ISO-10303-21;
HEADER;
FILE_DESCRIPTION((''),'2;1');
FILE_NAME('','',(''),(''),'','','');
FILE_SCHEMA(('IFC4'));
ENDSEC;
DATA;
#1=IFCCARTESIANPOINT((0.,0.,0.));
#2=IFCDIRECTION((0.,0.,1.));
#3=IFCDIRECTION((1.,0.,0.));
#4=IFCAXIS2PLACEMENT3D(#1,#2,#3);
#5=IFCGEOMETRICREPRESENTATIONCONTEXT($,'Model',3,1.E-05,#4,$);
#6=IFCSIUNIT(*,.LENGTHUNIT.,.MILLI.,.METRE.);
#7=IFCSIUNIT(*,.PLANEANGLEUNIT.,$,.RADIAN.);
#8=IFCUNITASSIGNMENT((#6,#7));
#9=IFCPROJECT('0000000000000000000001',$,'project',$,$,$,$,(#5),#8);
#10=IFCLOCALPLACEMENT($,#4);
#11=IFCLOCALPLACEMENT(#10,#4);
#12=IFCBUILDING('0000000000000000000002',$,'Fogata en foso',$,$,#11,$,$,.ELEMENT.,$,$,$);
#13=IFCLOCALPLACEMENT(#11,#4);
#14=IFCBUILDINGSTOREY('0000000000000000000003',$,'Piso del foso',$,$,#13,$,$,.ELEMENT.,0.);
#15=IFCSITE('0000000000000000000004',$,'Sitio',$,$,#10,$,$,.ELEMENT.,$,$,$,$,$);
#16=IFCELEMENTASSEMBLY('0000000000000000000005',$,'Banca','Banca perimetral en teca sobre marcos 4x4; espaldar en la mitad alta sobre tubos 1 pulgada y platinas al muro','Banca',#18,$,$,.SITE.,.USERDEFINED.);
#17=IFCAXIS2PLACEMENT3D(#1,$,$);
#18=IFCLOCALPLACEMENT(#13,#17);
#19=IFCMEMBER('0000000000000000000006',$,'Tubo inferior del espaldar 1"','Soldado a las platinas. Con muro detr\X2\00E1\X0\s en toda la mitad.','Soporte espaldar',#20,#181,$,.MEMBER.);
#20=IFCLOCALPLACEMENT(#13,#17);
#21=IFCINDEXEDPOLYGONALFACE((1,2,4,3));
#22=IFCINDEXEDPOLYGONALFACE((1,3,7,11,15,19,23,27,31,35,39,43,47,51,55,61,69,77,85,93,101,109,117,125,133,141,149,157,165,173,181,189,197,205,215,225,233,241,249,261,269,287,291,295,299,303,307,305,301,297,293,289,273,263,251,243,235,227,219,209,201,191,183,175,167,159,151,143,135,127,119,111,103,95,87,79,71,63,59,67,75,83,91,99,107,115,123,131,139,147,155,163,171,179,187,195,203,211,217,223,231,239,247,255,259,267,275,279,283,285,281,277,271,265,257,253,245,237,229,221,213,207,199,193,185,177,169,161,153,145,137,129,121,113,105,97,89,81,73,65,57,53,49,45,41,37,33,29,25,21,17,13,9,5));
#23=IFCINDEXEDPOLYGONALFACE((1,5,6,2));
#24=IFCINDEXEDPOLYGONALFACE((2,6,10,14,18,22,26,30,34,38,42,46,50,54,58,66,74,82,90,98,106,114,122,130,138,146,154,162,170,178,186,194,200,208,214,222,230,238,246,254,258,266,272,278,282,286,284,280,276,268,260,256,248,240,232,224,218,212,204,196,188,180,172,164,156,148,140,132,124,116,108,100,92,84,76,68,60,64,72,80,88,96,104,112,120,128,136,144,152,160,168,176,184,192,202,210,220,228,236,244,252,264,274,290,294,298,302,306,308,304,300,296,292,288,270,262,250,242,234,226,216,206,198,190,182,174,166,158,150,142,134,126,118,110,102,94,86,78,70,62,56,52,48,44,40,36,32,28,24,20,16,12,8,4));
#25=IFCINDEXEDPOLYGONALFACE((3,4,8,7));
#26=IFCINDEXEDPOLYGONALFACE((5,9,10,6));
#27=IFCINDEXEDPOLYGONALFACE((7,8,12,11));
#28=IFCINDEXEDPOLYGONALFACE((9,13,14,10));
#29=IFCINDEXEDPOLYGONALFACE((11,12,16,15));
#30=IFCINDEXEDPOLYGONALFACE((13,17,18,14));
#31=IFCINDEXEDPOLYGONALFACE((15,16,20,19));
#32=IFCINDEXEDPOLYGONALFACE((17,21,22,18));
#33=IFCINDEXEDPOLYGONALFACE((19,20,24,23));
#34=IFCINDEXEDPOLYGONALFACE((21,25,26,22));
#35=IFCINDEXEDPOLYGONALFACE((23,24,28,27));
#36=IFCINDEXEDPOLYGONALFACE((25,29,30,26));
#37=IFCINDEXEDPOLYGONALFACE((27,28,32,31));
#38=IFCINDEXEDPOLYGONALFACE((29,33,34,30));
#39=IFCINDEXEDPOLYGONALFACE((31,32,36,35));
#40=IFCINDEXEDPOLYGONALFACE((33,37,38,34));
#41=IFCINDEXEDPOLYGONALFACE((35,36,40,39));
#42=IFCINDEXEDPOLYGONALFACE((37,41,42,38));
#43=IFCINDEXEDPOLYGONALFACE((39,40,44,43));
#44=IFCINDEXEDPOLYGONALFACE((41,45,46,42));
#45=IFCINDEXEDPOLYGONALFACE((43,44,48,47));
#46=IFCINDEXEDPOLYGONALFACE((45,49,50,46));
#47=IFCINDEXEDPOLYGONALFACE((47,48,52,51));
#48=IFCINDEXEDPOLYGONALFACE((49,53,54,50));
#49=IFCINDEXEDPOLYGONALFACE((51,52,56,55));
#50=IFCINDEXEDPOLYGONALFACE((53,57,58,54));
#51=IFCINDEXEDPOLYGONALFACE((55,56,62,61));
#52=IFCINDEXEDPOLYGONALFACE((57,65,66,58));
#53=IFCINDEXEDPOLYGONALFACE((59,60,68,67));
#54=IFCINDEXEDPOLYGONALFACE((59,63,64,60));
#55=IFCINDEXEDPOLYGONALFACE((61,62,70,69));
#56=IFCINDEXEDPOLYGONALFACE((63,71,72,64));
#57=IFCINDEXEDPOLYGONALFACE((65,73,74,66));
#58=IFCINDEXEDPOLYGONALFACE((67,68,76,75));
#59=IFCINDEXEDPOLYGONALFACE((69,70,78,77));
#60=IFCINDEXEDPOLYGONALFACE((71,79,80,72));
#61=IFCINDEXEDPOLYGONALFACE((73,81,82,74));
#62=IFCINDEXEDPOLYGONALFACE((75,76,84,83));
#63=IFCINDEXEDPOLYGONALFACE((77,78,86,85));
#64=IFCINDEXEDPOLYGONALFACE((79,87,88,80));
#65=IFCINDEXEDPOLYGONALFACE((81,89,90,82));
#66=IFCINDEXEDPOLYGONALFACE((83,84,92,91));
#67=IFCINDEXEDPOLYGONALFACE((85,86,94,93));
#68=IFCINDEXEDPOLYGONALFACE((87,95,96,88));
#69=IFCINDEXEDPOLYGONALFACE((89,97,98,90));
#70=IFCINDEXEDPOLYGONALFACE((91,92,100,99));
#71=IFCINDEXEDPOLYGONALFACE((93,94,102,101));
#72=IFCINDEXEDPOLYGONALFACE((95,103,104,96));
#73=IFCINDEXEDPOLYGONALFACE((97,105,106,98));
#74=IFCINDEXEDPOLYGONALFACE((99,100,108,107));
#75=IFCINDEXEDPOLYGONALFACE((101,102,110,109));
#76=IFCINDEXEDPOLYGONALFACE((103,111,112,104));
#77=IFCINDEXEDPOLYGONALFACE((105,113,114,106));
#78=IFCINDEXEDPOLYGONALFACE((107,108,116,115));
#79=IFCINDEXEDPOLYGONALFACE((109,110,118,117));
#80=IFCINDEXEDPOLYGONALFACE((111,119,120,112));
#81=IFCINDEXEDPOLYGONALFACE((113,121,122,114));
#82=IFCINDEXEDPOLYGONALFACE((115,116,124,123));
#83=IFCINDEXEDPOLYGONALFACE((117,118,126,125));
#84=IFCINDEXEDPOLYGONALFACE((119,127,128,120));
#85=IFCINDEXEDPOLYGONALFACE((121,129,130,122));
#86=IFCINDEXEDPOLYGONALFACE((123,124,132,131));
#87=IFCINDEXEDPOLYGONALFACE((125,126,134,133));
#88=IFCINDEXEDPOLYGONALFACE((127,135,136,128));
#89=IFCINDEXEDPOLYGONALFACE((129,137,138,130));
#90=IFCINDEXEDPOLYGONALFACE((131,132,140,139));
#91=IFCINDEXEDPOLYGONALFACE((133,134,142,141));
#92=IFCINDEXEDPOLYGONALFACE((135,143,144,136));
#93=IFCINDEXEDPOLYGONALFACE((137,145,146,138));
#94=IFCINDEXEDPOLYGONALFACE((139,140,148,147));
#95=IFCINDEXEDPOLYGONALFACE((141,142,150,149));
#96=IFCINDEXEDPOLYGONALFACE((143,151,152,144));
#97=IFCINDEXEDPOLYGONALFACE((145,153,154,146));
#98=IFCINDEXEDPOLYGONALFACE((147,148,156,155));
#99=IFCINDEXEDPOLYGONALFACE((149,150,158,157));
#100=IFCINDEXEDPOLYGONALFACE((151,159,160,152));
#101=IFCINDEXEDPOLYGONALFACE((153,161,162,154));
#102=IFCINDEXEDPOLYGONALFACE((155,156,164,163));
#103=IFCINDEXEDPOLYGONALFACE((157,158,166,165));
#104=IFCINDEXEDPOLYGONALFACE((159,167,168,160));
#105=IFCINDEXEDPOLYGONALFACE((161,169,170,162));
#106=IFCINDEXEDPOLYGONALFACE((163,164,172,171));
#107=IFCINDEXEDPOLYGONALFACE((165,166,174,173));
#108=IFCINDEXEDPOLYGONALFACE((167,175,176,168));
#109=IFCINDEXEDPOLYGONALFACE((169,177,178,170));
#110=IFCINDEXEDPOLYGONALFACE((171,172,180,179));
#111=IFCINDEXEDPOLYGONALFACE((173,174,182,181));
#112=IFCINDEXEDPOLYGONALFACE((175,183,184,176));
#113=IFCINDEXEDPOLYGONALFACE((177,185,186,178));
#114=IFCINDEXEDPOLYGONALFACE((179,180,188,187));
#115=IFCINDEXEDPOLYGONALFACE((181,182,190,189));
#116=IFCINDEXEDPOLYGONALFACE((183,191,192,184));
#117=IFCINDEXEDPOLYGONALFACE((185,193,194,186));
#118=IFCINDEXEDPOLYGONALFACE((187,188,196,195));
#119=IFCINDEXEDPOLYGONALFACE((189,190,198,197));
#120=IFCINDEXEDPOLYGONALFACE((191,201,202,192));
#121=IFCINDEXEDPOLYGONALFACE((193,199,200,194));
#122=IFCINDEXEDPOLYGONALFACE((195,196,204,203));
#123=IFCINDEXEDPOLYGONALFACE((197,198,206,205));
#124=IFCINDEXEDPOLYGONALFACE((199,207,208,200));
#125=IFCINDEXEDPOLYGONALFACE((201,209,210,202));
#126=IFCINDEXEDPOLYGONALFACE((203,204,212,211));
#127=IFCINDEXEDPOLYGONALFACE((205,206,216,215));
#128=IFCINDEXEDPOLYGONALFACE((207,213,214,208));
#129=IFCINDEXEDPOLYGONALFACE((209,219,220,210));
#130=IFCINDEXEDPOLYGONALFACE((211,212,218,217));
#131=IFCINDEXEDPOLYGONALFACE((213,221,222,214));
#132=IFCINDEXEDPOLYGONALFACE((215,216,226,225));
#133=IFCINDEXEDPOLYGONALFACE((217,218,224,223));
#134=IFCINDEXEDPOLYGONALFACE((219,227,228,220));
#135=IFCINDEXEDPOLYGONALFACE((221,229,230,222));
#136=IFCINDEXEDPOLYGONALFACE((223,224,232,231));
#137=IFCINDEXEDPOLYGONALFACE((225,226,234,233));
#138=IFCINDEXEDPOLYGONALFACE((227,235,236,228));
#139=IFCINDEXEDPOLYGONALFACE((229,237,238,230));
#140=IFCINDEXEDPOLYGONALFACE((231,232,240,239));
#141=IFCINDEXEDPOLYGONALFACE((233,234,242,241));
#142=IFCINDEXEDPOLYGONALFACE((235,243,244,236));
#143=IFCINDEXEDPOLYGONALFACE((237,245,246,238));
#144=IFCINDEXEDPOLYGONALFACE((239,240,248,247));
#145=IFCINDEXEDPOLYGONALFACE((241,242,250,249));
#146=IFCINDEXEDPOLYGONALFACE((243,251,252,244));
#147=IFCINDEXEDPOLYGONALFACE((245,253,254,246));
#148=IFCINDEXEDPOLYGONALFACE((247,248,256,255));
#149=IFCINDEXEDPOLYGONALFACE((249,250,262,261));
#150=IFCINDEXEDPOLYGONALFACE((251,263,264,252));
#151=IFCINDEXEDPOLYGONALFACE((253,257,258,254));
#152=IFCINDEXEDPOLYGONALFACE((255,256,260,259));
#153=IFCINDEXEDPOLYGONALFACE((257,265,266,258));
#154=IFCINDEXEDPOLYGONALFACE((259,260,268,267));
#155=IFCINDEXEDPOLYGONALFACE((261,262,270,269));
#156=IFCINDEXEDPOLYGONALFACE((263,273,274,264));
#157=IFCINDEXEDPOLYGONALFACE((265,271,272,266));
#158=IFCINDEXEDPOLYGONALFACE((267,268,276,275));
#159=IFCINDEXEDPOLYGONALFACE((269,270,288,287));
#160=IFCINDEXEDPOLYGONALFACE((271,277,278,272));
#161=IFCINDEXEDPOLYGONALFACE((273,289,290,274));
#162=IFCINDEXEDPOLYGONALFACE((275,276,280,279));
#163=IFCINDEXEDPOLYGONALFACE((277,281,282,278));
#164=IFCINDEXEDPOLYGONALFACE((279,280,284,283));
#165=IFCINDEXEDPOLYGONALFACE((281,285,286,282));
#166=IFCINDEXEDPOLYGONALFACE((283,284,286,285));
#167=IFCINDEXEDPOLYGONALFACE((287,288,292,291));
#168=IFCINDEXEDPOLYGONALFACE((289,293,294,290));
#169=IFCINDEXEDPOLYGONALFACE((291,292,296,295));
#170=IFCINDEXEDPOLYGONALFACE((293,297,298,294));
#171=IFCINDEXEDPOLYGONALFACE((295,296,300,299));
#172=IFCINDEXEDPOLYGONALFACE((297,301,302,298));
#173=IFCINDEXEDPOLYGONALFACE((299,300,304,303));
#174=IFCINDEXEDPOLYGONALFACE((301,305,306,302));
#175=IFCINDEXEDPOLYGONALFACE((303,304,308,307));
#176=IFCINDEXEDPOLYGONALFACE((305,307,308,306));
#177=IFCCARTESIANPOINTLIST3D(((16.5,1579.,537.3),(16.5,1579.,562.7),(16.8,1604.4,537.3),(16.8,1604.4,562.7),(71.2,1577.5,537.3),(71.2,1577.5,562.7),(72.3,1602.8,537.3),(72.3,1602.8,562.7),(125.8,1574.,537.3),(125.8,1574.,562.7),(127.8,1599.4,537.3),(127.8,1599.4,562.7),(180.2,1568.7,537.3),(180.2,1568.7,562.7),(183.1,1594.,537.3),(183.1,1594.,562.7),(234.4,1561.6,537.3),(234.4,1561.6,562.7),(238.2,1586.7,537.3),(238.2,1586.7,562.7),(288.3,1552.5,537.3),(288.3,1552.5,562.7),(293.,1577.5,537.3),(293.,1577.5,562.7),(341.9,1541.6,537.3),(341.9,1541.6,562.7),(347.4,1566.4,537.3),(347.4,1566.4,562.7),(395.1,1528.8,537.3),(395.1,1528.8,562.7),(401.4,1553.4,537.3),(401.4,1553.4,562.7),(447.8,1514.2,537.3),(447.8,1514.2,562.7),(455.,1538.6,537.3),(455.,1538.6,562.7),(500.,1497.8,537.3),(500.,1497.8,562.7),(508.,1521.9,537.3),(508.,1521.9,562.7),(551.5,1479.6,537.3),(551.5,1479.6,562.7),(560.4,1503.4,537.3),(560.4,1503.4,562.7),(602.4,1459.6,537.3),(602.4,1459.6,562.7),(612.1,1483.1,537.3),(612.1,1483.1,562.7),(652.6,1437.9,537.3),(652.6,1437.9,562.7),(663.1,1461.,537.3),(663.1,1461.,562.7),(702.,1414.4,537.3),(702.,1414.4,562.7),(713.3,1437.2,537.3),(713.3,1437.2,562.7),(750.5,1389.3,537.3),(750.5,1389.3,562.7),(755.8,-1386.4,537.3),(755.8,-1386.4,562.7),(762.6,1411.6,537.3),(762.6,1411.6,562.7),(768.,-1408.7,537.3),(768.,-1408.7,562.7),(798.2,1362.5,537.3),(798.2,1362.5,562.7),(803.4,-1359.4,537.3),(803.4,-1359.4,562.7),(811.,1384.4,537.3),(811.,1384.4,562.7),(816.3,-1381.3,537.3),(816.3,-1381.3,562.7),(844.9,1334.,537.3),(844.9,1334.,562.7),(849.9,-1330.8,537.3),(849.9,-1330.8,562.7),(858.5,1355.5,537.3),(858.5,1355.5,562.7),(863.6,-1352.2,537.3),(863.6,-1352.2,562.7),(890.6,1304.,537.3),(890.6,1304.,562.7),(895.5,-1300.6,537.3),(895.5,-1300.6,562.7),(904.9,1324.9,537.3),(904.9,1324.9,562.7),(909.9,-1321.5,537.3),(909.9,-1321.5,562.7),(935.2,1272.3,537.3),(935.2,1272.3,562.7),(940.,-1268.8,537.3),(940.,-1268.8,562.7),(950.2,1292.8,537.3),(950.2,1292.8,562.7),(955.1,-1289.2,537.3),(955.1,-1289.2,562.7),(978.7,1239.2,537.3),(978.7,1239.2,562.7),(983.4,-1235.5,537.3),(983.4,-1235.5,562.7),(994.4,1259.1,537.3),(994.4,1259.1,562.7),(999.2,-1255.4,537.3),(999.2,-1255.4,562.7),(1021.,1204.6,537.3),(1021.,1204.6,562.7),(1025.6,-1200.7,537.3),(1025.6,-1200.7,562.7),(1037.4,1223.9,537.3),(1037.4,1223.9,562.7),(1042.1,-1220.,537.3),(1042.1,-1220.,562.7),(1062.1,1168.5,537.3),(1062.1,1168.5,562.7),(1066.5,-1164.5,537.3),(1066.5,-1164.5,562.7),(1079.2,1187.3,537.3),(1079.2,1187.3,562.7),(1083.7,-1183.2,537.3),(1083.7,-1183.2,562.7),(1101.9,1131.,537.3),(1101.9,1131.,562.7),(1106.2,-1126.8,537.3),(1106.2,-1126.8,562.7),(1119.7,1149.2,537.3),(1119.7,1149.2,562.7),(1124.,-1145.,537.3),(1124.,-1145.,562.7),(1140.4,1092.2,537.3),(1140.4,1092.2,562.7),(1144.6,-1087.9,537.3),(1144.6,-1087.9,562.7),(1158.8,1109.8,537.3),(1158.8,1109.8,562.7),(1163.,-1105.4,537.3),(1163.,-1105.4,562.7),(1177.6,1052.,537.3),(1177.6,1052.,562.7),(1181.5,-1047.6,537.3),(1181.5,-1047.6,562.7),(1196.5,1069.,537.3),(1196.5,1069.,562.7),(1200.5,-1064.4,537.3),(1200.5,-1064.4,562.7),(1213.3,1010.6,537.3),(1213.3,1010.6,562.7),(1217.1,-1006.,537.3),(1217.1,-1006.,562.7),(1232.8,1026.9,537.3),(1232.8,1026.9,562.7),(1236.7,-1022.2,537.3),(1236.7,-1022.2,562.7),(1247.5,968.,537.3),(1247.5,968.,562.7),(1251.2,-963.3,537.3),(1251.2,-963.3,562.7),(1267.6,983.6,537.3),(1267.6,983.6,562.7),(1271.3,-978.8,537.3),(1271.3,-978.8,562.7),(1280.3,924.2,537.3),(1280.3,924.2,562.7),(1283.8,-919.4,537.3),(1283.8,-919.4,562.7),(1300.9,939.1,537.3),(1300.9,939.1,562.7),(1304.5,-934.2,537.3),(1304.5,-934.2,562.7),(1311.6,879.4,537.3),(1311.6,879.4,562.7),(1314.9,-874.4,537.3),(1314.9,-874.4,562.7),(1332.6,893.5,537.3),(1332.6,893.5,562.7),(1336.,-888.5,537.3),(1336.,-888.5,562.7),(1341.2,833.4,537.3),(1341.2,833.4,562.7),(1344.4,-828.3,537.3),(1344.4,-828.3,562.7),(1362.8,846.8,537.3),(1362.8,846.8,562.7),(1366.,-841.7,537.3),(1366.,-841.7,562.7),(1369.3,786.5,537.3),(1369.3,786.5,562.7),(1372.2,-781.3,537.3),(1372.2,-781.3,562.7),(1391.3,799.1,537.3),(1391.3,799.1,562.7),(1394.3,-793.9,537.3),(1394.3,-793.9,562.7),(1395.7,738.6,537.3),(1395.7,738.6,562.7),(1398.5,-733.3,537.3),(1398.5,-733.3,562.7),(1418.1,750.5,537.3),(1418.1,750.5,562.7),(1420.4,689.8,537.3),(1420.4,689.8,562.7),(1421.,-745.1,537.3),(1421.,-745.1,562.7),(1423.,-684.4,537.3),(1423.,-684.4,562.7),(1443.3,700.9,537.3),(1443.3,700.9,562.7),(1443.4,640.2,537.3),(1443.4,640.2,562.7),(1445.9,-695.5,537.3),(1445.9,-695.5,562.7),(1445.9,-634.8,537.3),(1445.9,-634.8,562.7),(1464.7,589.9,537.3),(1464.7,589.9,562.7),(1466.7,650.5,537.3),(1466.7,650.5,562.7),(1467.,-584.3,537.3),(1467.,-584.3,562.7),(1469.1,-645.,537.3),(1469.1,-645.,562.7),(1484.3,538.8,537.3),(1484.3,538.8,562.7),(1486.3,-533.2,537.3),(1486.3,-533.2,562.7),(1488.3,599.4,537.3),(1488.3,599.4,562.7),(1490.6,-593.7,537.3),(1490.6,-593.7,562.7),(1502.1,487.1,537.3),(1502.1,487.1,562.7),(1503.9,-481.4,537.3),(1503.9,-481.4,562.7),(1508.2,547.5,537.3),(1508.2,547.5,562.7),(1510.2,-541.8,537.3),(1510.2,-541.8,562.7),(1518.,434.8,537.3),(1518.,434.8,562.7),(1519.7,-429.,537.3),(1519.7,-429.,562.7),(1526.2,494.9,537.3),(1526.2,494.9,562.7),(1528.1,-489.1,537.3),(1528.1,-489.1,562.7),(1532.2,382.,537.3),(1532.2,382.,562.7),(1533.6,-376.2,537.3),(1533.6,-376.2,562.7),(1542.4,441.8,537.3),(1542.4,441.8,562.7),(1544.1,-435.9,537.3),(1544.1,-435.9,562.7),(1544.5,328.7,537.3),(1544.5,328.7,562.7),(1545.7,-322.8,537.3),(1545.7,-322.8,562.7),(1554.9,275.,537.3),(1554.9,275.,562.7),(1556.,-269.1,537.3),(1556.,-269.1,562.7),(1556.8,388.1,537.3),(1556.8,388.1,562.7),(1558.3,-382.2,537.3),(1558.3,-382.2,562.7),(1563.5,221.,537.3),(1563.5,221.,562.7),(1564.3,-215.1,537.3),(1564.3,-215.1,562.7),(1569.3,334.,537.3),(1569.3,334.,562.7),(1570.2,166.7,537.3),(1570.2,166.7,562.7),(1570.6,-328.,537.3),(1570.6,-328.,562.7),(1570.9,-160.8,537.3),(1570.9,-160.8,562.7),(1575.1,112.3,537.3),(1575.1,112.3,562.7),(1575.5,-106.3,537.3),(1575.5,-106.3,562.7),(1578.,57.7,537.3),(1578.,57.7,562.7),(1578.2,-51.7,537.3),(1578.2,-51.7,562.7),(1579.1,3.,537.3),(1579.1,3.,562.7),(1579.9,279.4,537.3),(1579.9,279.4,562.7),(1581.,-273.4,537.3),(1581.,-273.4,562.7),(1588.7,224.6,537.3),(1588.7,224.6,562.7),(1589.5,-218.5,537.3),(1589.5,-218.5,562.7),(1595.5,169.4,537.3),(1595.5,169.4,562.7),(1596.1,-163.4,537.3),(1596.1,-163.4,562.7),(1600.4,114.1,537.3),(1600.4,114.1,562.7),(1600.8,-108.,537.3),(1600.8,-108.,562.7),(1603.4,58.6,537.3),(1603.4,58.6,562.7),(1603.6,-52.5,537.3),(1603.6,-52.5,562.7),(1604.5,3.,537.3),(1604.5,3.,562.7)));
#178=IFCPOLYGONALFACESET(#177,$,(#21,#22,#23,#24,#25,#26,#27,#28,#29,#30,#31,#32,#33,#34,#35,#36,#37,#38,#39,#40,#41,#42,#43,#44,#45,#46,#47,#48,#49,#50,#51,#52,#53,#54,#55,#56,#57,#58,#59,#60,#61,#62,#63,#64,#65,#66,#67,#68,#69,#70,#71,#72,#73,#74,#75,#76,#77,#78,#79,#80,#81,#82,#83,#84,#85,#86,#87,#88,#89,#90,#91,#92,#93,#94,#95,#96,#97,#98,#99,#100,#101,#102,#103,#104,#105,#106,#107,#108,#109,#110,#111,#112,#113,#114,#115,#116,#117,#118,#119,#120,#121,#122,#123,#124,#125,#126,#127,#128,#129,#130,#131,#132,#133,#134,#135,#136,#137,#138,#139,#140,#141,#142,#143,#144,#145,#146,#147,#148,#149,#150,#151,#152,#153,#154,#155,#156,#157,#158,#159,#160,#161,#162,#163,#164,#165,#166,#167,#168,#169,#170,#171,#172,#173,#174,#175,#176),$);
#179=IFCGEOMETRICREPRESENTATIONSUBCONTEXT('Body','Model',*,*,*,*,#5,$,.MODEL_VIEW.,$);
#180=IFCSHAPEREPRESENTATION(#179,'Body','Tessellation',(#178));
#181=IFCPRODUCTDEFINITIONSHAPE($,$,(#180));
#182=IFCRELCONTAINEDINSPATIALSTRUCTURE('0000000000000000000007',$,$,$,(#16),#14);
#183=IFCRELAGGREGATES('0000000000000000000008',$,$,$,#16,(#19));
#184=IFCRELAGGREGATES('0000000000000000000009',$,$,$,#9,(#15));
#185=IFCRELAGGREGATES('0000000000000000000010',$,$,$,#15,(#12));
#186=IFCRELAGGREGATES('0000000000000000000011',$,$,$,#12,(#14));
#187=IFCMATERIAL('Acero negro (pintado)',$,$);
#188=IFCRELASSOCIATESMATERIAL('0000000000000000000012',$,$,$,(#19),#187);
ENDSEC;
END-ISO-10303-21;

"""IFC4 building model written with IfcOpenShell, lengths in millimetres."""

from ifc_helpers import new_model, si_unit, frame, origin_with_axes, place, context, subcontext, project, spatial, polyline, outline, extrude, material, element, aggregate, save


model = new_model("IFC4")

# Units and contexts
model_context = context("Model", 3, precision=1e-05, world=origin_with_axes())
body_context = subcontext(model_context, "Body", "Model", "MODEL_VIEW")
ifc_project = project(units=[si_unit("LENGTHUNIT", "METRE", prefix="MILLI"), si_unit("PLANEANGLEUNIT", "RADIAN")], contexts=[model_context])

# Site, building, storey
site_placement = place(None, origin_with_axes())
site = spatial("IfcSite", under=ifc_project, at=site_placement, Name="Sitio", CompositionType="ELEMENT")
building_placement = place(site_placement, origin_with_axes())
building = spatial("IfcBuilding", under=site, at=building_placement, Name="Fogata en foso", CompositionType="ELEMENT")
storey_placement = place(building_placement, origin_with_axes())
storey = spatial("IfcBuildingStorey", under=building, at=storey_placement, Name="Piso del foso", CompositionType="ELEMENT", Elevation=0.0)

# Element assembly, member
assembly_1_placement = place(storey_placement, origin_with_axes())
assembly_1 = element("IfcElementAssembly", 1, at=assembly_1_placement, inside=storey, Name="Banca", Description="Banca perimetral en teca sobre marcos 4x4; espaldar en la mitad alta sobre tubos 1 pulgada y platinas al muro", ObjectType="Banca", AssemblyPlace="SITE", PredefinedType="USERDEFINED")
ifc_material_1 = material(Name="Acero negro (pintado)")
member_1_placement = place(storey_placement, frame((0.0, 0.0, 537.3), z_axis=(0.0, 0.0, 1.0), x_axis=(1.0, 0.0, 0.0)))
member_1 = element("IfcMember", 2, at=member_1_placement, material=ifc_material_1, Name="Tubo inferior del espaldar 1\"", Description="Soldado a las platinas. Con muro detrás en toda la mitad.", ObjectType="Soporte espaldar", PredefinedType="MEMBER", context=body_context, shape_type="SweptSolid", body=[
    extrude(outline(polyline([(768.0, -1408.7), (816.3, -1381.3), (863.6, -1352.2), (909.9, -1321.5), (955.1, -1289.2), (999.2, -1255.4), (1042.1, -1220.0), (1083.7, -1183.2), (1124.0, -1145.0), (1163.0, -1105.4), (1200.5, -1064.4), (1236.7, -1022.2), (1271.3, -978.8), (1304.5, -934.2), (1336.0, -888.5), (1366.0, -841.7), (1394.3, -793.9), (1421.0, -745.1), (1445.9, -695.5), (1469.1, -645.0), (1490.6, -593.7), (1510.2, -541.8), (1528.1, -489.1), (1544.1, -435.9), (1558.3, -382.2), (1570.6, -328.0), (1581.0, -273.4), (1589.5, -218.5), (1596.1, -163.4), (1600.8, -108.0), (1603.6, -52.5), (1604.5, 3.0), (1603.4, 58.6), (1600.4, 114.1), (1595.5, 169.4), (1588.7, 224.6), (1579.9, 279.4), (1569.3, 334.0), (1556.8, 388.1), (1542.4, 441.8), (1526.2, 494.9), (1508.2, 547.5), (1488.3, 599.4), (1466.7, 650.5), (1443.3, 700.9), (1418.1, 750.5), (1391.3, 799.1), (1362.8, 846.8), (1332.6, 893.5), (1300.9, 939.1), (1267.6, 983.6), (1232.8, 1026.9), (1196.5, 1069.0), (1158.8, 1109.8), (1119.7, 1149.2), (1079.2, 1187.3), (1037.4, 1223.9), (994.4, 1259.1), (950.2, 1292.8), (904.9, 1324.9), (858.5, 1355.5), (811.0, 1384.4), (762.6, 1411.6), (713.3, 1437.2), (663.1, 1461.0), (612.1, 1483.1), (560.4, 1503.4), (508.0, 1521.9), (455.0, 1538.6), (401.4, 1553.4), (347.4, 1566.4), (293.0, 1577.5), (238.2, 1586.7), (183.1, 1594.0), (127.8, 1599.4), (72.3, 1602.8), (16.8, 1604.4), (16.5, 1579.0), (71.2, 1577.5), (125.8, 1574.0), (180.2, 1568.7), (234.4, 1561.6), (288.3, 1552.5), (341.9, 1541.6), (395.1, 1528.8), (447.8, 1514.2), (500.0, 1497.8), (551.5, 1479.6), (602.4, 1459.6), (652.6, 1437.9), (702.0, 1414.4), (750.5, 1389.3), (798.2, 1362.5), (844.9, 1334.0), (890.6, 1304.0), (935.2, 1272.3), (978.7, 1239.2), (1021.0, 1204.6), (1062.1, 1168.5), (1101.9, 1131.0), (1140.4, 1092.2), (1177.6, 1052.0), (1213.3, 1010.6), (1247.5, 968.0), (1280.3, 924.2), (1311.5, 879.4), (1341.2, 833.4), (1369.3, 786.5), (1395.7, 738.6), (1420.4, 689.8), (1443.4, 640.2), (1464.7, 589.9), (1484.3, 538.8), (1502.1, 487.1), (1518.0, 434.8), (1532.2, 382.0), (1544.5, 328.7), (1554.9, 275.0), (1563.5, 221.0), (1570.2, 166.7), (1575.1, 112.3), (1578.0, 57.7), (1579.1, 3.0), (1578.2, -51.7), (1575.5, -106.3), (1570.9, -160.8), (1564.3, -215.1), (1556.0, -269.1), (1545.7, -322.8), (1533.6, -376.2), (1519.7, -429.0), (1503.9, -481.4), (1486.3, -533.2), (1467.0, -584.3), (1445.9, -634.8), (1423.0, -684.4), (1398.5, -733.3), (1372.2, -781.3), (1344.4, -828.3), (1314.9, -874.4), (1283.8, -919.4), (1251.2, -963.3), (1217.1, -1006.0), (1181.5, -1047.6), (1144.6, -1087.9), (1106.2, -1126.8), (1066.5, -1164.5), (1025.6, -1200.7), (983.4, -1235.5), (940.0, -1268.8), (895.5, -1300.6), (849.9, -1330.8), (803.4, -1359.4), (755.8, -1386.4), (768.0, -1408.7)])), origin_with_axes(), (0.0, 0.0, 1.0), 25.4),
])
aggregate(assembly_1, [member_1])

save(model, "model.ifc")
